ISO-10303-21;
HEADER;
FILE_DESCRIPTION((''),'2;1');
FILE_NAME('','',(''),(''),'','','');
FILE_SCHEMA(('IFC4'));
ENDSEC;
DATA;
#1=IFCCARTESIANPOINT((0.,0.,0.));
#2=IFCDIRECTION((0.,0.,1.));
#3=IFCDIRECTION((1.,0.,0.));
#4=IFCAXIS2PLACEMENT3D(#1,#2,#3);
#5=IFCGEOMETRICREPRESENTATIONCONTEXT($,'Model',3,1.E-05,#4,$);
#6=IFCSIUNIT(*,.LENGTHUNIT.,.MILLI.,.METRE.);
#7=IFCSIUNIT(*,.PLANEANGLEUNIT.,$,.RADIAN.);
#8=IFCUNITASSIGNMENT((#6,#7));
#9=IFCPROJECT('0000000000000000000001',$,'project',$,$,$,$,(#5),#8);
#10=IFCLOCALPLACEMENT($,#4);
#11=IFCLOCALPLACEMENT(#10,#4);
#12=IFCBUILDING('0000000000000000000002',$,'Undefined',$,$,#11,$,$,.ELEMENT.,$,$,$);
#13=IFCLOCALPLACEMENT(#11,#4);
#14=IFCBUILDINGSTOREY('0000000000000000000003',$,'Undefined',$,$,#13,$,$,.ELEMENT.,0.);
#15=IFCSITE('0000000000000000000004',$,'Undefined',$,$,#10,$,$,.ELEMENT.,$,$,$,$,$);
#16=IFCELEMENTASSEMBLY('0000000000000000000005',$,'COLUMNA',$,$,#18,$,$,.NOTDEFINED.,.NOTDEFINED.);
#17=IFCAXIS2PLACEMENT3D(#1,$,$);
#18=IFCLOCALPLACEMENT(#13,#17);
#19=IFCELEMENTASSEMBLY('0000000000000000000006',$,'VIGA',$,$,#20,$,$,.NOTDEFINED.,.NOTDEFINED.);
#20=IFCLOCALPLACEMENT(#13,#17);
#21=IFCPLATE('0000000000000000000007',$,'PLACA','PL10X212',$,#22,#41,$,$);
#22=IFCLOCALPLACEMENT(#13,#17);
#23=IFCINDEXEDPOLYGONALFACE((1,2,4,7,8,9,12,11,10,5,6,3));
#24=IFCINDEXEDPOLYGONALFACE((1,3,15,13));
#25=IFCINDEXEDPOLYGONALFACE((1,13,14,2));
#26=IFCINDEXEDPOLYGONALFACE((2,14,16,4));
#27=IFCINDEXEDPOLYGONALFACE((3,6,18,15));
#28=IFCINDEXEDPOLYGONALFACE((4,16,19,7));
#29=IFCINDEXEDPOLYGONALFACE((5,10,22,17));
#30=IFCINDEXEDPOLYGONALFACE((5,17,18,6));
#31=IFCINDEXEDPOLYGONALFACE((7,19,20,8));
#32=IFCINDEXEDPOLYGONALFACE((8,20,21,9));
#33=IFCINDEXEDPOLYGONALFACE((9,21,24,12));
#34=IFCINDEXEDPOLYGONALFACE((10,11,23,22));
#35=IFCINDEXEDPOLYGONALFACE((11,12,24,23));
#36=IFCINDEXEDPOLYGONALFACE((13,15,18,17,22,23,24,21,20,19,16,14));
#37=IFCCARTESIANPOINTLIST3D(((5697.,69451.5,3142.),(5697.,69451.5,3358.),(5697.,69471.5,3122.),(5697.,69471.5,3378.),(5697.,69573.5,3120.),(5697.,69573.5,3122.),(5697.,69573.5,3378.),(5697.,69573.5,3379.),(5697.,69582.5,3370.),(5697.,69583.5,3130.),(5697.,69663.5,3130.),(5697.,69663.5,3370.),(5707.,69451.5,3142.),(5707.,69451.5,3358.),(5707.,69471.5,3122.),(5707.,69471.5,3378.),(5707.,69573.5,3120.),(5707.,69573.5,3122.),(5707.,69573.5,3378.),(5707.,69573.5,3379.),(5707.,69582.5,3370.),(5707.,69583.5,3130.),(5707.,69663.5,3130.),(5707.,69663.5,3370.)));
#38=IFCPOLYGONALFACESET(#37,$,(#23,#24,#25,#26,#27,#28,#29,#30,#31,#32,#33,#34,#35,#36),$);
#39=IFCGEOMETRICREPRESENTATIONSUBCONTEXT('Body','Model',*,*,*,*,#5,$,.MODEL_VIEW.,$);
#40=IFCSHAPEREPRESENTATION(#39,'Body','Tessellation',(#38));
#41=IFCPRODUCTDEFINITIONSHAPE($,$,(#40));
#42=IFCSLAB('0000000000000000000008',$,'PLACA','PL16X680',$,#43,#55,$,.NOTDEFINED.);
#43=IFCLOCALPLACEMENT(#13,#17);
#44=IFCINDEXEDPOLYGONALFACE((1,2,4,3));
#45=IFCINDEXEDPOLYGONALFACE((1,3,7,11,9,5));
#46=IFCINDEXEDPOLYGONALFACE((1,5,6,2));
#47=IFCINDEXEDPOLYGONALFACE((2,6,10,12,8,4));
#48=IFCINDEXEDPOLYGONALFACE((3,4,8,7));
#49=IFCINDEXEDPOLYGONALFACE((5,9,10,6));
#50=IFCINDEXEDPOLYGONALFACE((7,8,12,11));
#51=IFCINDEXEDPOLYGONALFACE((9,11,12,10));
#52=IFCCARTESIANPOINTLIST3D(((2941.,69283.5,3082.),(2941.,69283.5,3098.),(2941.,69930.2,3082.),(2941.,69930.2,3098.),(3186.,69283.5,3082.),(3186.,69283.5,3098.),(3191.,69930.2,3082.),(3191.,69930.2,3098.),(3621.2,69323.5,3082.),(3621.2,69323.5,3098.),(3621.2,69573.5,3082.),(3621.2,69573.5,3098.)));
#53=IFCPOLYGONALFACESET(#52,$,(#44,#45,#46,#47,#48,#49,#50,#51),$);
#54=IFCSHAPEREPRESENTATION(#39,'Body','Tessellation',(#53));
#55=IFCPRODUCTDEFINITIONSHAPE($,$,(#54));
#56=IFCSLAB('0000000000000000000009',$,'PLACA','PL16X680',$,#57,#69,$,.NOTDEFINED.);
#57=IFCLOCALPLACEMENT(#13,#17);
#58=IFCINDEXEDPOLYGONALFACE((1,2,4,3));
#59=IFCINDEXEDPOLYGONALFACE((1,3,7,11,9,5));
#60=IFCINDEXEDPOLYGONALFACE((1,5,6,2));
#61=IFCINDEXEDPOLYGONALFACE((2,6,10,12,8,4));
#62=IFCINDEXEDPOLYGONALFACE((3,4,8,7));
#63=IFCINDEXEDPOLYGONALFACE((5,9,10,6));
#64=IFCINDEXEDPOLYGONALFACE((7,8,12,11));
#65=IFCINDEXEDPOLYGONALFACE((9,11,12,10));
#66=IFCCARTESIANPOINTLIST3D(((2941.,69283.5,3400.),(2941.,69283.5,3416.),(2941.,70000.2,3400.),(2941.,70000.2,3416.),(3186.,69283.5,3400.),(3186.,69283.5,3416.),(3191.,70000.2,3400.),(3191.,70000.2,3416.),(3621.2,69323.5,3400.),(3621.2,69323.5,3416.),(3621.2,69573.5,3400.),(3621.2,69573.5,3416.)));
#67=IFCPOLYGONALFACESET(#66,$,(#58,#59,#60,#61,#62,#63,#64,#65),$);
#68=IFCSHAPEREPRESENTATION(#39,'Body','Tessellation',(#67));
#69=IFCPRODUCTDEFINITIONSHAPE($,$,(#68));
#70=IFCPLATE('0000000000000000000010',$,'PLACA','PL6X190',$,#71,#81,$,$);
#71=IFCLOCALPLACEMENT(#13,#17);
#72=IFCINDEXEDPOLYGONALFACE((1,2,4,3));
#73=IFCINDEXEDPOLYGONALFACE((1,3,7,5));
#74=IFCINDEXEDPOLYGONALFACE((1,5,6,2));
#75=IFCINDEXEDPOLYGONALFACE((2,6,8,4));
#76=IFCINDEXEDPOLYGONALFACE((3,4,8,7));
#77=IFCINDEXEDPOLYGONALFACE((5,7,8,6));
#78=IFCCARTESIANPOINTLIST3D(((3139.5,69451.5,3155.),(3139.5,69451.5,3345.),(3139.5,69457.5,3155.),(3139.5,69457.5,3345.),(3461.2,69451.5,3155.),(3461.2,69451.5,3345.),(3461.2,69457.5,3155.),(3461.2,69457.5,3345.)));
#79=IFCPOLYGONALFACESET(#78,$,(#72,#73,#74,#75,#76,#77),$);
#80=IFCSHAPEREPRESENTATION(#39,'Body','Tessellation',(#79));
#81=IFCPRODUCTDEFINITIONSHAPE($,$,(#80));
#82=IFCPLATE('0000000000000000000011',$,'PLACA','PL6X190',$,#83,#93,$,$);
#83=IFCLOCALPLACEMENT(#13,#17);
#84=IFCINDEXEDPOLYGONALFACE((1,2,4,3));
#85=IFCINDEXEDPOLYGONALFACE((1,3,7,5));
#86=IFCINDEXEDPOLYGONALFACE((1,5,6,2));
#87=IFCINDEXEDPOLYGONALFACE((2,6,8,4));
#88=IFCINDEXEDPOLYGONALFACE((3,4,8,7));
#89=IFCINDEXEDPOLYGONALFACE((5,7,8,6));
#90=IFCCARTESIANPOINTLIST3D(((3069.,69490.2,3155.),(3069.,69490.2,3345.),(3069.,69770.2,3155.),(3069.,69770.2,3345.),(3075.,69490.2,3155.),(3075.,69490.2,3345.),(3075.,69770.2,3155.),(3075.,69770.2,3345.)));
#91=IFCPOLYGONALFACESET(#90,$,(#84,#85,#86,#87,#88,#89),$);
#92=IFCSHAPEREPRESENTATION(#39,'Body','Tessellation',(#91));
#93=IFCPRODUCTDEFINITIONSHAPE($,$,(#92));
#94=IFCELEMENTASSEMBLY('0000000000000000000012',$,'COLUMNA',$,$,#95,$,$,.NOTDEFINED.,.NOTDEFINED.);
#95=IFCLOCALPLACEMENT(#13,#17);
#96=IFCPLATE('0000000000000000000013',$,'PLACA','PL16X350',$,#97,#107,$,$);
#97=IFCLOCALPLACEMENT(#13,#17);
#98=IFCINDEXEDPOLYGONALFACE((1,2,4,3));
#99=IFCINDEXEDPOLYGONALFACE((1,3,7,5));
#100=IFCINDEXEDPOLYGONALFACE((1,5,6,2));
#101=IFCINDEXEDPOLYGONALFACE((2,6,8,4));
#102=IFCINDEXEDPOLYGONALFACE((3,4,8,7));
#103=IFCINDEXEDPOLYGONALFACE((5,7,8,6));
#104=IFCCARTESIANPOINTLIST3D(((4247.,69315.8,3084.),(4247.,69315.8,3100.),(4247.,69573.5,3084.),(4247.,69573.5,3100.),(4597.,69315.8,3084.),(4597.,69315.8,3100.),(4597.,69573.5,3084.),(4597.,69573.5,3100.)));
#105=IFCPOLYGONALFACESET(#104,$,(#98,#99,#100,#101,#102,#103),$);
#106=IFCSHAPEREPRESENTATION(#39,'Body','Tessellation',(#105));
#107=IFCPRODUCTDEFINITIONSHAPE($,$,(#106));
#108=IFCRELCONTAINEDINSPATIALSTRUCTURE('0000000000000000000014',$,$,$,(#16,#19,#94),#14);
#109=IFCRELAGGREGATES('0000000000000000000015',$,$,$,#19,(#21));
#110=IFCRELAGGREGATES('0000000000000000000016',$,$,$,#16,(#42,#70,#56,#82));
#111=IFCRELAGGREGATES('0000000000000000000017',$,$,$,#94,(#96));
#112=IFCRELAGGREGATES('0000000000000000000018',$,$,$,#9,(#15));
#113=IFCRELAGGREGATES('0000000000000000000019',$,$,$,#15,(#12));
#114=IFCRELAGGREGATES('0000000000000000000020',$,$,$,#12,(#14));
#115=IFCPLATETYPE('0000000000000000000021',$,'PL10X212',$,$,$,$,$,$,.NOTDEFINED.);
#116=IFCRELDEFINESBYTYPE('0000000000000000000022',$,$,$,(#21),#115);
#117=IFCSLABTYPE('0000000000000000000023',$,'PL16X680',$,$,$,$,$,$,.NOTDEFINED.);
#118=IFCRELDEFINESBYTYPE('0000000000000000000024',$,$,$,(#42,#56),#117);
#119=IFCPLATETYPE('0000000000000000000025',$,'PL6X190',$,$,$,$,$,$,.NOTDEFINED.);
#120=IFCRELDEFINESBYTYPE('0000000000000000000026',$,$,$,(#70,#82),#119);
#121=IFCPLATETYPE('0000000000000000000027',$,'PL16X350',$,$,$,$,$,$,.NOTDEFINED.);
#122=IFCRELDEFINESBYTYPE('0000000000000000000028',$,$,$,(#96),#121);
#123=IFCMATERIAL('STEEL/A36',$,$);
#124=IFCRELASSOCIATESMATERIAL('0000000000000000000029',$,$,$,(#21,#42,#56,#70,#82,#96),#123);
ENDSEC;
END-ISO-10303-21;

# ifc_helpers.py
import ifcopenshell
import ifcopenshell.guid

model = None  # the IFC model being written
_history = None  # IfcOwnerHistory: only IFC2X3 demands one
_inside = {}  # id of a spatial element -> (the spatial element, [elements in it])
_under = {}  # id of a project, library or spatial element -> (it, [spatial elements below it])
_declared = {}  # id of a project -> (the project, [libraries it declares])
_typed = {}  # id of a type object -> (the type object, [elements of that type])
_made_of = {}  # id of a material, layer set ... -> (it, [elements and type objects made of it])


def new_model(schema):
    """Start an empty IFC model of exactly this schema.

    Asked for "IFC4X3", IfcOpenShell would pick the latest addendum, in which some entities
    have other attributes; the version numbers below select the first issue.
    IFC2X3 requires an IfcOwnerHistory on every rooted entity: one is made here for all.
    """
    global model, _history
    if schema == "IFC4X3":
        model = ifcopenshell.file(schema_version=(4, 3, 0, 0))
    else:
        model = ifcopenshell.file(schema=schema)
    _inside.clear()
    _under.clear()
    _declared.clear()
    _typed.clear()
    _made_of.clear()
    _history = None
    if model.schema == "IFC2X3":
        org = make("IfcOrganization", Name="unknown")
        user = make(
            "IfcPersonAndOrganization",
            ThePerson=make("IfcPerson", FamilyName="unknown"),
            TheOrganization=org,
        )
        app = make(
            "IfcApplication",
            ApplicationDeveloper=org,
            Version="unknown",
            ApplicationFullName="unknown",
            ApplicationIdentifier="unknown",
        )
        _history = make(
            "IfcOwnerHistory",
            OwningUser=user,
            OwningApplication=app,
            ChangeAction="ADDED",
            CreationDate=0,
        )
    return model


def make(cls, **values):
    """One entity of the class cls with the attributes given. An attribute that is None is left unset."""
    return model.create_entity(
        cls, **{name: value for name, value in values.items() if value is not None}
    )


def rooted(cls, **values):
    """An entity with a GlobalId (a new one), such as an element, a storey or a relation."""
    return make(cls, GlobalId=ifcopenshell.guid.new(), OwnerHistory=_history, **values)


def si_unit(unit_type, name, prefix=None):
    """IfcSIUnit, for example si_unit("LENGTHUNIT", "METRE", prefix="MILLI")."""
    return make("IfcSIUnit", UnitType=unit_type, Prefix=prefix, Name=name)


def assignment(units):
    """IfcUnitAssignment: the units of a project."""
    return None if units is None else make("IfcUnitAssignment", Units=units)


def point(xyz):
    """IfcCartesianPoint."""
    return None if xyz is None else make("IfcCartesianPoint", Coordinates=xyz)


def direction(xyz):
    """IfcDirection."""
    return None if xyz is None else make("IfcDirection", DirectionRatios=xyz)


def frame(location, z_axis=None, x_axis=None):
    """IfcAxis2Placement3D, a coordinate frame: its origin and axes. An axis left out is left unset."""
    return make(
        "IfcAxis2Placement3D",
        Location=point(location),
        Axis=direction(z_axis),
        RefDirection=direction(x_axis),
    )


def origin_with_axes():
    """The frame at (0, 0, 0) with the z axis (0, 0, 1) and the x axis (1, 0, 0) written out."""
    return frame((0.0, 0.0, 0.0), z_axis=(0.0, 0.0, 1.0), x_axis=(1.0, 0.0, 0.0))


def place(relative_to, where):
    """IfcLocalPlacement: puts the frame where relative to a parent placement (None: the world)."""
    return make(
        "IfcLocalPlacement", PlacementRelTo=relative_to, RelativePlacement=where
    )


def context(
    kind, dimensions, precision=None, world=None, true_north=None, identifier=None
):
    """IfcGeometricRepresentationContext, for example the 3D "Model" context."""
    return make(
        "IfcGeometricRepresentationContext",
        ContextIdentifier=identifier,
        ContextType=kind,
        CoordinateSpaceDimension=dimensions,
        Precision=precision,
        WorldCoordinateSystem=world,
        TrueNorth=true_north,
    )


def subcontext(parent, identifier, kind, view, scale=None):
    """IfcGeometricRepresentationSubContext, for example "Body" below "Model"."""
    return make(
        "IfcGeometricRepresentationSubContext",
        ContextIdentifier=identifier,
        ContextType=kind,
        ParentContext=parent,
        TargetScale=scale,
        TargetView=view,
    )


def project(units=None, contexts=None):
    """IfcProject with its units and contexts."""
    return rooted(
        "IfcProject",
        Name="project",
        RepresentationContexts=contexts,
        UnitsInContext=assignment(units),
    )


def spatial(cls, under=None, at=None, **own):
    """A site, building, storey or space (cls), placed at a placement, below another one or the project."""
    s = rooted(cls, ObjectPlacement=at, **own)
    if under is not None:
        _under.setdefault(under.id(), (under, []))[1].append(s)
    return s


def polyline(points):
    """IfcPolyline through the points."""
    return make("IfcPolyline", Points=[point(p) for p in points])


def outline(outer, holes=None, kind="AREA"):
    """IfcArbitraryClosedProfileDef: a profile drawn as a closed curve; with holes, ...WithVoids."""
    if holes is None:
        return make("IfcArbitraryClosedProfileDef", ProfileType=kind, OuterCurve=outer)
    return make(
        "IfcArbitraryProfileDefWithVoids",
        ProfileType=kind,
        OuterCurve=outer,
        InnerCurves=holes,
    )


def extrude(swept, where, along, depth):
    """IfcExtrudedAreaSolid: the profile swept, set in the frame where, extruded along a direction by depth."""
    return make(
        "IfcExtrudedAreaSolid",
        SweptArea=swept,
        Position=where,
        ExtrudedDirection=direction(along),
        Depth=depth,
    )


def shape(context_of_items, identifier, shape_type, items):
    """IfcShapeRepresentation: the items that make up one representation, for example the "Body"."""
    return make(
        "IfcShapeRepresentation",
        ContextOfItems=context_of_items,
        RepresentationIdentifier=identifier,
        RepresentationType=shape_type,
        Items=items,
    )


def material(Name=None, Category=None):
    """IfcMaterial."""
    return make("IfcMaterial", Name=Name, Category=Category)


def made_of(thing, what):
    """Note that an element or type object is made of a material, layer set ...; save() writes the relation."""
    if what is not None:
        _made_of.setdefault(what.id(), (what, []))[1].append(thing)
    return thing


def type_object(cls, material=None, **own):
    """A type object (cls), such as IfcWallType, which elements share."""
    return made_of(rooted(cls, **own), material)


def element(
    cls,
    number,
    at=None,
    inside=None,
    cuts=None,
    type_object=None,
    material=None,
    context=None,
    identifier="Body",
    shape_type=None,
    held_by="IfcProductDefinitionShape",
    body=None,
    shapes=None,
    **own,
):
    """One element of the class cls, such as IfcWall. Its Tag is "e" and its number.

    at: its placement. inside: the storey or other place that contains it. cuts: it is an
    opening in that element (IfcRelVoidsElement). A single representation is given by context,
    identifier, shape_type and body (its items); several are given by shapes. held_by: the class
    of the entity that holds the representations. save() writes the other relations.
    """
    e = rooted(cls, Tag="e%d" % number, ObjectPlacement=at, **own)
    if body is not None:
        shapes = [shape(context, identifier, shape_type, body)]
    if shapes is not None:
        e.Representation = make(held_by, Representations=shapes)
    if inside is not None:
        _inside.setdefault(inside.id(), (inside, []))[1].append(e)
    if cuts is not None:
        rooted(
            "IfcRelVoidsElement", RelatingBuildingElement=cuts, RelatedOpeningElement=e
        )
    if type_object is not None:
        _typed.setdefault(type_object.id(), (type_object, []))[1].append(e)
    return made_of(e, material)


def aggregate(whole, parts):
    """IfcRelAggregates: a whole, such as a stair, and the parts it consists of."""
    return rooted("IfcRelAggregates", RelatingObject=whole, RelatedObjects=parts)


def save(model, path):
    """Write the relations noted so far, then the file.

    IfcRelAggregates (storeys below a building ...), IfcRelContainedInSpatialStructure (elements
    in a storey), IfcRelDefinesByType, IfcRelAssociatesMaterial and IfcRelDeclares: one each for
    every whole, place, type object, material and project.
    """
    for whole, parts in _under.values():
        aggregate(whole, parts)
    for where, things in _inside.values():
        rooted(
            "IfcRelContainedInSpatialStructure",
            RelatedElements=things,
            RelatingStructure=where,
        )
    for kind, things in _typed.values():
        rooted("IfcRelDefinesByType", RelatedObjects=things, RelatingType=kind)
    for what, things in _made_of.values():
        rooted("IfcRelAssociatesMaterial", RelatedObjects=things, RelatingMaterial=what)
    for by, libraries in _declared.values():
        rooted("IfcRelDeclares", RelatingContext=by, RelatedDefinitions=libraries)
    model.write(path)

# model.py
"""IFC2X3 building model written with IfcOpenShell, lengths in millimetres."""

from ifc_helpers import new_model, si_unit, frame, origin_with_axes, place, context, subcontext, project, spatial, polyline, outline, extrude, material, type_object, element, aggregate, save


model = new_model("IFC2X3")

# Units and contexts
model_context = context("Model", 3, precision=1e-05, world=origin_with_axes())
body_context = subcontext(model_context, "Body", "Model", "MODEL_VIEW")
ifc_project = project(units=[si_unit("LENGTHUNIT", "METRE", prefix="MILLI"), si_unit("PLANEANGLEUNIT", "RADIAN")], contexts=[model_context])

# Site, building, storey
site_placement = place(None, origin_with_axes())
site = spatial("IfcSite", under=ifc_project, at=site_placement, Name="Undefined", CompositionType="ELEMENT")
building_placement = place(site_placement, origin_with_axes())
building = spatial("IfcBuilding", under=site, at=building_placement, Name="Undefined", CompositionType="ELEMENT")
storey_placement = place(building_placement, origin_with_axes())
storey = spatial("IfcBuildingStorey", under=building, at=storey_placement, Name="Undefined", CompositionType="ELEMENT", Elevation=0.0)

# Element assembly
assembly_1_placement = place(storey_placement, origin_with_axes())
assembly_1 = element("IfcElementAssembly", 1, at=assembly_1_placement, inside=storey, Name="COLUMNA", AssemblyPlace="NOTDEFINED", PredefinedType="NOTDEFINED")
ifc_material_1 = material(Name="STEEL/A36")

# Element assembly
assembly_2_placement = place(storey_placement, origin_with_axes())
assembly_2 = element("IfcElementAssembly", 2, at=assembly_2_placement, inside=storey, Name="VIGA", AssemblyPlace="NOTDEFINED", PredefinedType="NOTDEFINED")

# Plate
plate_type_1 = type_object("IfcPlateType", Name="PL10X212", PredefinedType="NOTDEFINED")
plate_1_placement = place(assembly_2_placement, frame((5702.0, 69451.5, 3142.0), z_axis=(1.0, 0.0, 0.0), x_axis=(0.0, 0.707107, -0.707107)))
plate_1 = element("IfcPlate", 3, at=plate_1_placement, type_object=plate_type_1, material=ifc_material_1, Name="PLACA", Description="PL10X212", context=body_context, shape_type="SweptSolid", body=[
    extrude(outline(polyline([(0.0, 0.0), (28.3, 0.0), (100.4, 72.1), (101.8, 70.7), (101.8, 84.9), (158.4, 141.4), (-11.3, 311.1), (-68.6, 253.9), (-81.3, 253.9), (-80.6, 253.1), (-152.7, 181.0), (-152.7, 152.7), (0.0, 0.0)])), frame((0.0, 0.0, -5.0), z_axis=(0.0, 0.0, 1.0), x_axis=(1.0, 0.0, 0.0)), (0.0, 0.0, 1.0), 10.0),
])

# Slabs
slab_type = type_object("IfcSlabType", Name="PL16X680", PredefinedType="NOTDEFINED")
slab_1_placement = place(assembly_1_placement, frame((3186.0, 69283.5, 3090.0), z_axis=(0.0, 0.0, 1.0), x_axis=(0.995803, 0.091521, 0.0)))
slab_1 = element("IfcSlab", 4, at=slab_1_placement, type_object=slab_type, material=ifc_material_1, Name="PLACA", Description="PL16X680", PredefinedType="NOTDEFINED", context=body_context, shape_type="SweptSolid", body=[
    extrude(outline(polyline([(0.0, 0.0), (437.1, 0.0), (459.9, 249.0), (64.2, 643.6), (-184.8, 666.4), (-244.0, 22.4), (0.0, 0.0)])), frame((0.0, 0.0, -8.0), z_axis=(0.0, 0.0, 1.0), x_axis=(1.0, 0.0, 0.0)), (0.0, 0.0, 1.0), 16.0),
])
slab_2_placement = place(assembly_1_placement, frame((3186.0, 69283.5, 3408.0), z_axis=(0.0, 0.0, 1.0), x_axis=(0.995803, 0.091521, 0.0)))
slab_2 = element("IfcSlab", 5, at=slab_2_placement, type_object=slab_type, material=ifc_material_1, Name="PLACA", Description="PL16X680", PredefinedType="NOTDEFINED", context=body_context, shape_type="SweptSolid", body=[
    extrude(outline(polyline([(0.0, 0.0), (437.1, 0.0), (459.9, 249.0), (70.6, 713.3), (-178.4, 736.1), (-244.0, 22.4), (0.0, 0.0)])), frame((0.0, 0.0, -8.0), z_axis=(0.0, 0.0, 1.0), x_axis=(1.0, 0.0, 0.0)), (0.0, 0.0, 1.0), 16.0),
])

# Plates
plate_type_2 = type_object("IfcPlateType", Name="PL6X190", PredefinedType="NOTDEFINED")
plate_2_placement = place(assembly_1_placement, frame((3461.2, 69454.5, 3250.0), z_axis=(0.0, 1.0, 0.0), x_axis=(-1.0, 0.0, 0.0)))
plate_2 = element("IfcPlate", 6, at=plate_2_placement, type_object=plate_type_2, material=ifc_material_1, Name="PLACA", Description="PL6X190", context=body_context, shape_type="SweptSolid", body=[
    extrude(outline(polyline([(0.0, -95.0), (0.0, 95.0), (321.7, 95.0), (321.7, -95.0), (0.0, -95.0)])), frame((0.0, 0.0, -3.0), z_axis=(0.0, 0.0, 1.0), x_axis=(1.0, 0.0, 0.0)), (0.0, 0.0, 1.0), 6.0),
])
plate_3_placement = place(assembly_1_placement, frame((3072.0, 69770.2, 3250.0), z_axis=(-1.0, 0.0, 0.0), x_axis=(0.0, -1.0, 0.0)))
plate_3 = element("IfcPlate", 7, at=plate_3_placement, type_object=plate_type_2, material=ifc_material_1, Name="PLACA", Description="PL6X190", context=body_context, shape_type="SweptSolid", body=[
    extrude(outline(polyline([(0.0, -95.0), (0.0, 95.0), (280.0, 95.0), (280.0, -95.0), (0.0, -95.0)])), frame((0.0, 0.0, -3.0), z_axis=(0.0, 0.0, 1.0), x_axis=(1.0, 0.0, 0.0)), (0.0, 0.0, 1.0), 6.0),
])

# Element assembly, plate
assembly_3_placement = place(storey_placement, origin_with_axes())
assembly_3 = element("IfcElementAssembly", 8, at=assembly_3_placement, inside=storey, Name="COLUMNA", AssemblyPlace="NOTDEFINED", PredefinedType="NOTDEFINED")
plate_type_3 = type_object("IfcPlateType", Name="PL16X350", PredefinedType="NOTDEFINED")
plate_4_placement = place(assembly_3_placement, frame((4422.0, 69315.8, 3092.0), z_axis=(0.0, 0.0, -1.0), x_axis=(0.0, 1.0, 0.0)))
plate_4 = element("IfcPlate", 9, at=plate_4_placement, type_object=plate_type_3, material=ifc_material_1, Name="PLACA", Description="PL16X350", context=body_context, shape_type="SweptSolid", body=[
    extrude(outline(polyline([(0.0, -175.0), (0.0, 175.0), (257.7, 175.0), (257.7, -175.0), (0.0, -175.0)])), frame((0.0, 0.0, -8.0), z_axis=(0.0, 0.0, 1.0), x_axis=(1.0, 0.0, 0.0)), (0.0, 0.0, 1.0), 16.0),
])

aggregate(assembly_2, [plate_1])
aggregate(assembly_1, [slab_1, plate_2, slab_2, plate_3])
aggregate(assembly_3, [plate_4])

save(model, "model.ifc")
